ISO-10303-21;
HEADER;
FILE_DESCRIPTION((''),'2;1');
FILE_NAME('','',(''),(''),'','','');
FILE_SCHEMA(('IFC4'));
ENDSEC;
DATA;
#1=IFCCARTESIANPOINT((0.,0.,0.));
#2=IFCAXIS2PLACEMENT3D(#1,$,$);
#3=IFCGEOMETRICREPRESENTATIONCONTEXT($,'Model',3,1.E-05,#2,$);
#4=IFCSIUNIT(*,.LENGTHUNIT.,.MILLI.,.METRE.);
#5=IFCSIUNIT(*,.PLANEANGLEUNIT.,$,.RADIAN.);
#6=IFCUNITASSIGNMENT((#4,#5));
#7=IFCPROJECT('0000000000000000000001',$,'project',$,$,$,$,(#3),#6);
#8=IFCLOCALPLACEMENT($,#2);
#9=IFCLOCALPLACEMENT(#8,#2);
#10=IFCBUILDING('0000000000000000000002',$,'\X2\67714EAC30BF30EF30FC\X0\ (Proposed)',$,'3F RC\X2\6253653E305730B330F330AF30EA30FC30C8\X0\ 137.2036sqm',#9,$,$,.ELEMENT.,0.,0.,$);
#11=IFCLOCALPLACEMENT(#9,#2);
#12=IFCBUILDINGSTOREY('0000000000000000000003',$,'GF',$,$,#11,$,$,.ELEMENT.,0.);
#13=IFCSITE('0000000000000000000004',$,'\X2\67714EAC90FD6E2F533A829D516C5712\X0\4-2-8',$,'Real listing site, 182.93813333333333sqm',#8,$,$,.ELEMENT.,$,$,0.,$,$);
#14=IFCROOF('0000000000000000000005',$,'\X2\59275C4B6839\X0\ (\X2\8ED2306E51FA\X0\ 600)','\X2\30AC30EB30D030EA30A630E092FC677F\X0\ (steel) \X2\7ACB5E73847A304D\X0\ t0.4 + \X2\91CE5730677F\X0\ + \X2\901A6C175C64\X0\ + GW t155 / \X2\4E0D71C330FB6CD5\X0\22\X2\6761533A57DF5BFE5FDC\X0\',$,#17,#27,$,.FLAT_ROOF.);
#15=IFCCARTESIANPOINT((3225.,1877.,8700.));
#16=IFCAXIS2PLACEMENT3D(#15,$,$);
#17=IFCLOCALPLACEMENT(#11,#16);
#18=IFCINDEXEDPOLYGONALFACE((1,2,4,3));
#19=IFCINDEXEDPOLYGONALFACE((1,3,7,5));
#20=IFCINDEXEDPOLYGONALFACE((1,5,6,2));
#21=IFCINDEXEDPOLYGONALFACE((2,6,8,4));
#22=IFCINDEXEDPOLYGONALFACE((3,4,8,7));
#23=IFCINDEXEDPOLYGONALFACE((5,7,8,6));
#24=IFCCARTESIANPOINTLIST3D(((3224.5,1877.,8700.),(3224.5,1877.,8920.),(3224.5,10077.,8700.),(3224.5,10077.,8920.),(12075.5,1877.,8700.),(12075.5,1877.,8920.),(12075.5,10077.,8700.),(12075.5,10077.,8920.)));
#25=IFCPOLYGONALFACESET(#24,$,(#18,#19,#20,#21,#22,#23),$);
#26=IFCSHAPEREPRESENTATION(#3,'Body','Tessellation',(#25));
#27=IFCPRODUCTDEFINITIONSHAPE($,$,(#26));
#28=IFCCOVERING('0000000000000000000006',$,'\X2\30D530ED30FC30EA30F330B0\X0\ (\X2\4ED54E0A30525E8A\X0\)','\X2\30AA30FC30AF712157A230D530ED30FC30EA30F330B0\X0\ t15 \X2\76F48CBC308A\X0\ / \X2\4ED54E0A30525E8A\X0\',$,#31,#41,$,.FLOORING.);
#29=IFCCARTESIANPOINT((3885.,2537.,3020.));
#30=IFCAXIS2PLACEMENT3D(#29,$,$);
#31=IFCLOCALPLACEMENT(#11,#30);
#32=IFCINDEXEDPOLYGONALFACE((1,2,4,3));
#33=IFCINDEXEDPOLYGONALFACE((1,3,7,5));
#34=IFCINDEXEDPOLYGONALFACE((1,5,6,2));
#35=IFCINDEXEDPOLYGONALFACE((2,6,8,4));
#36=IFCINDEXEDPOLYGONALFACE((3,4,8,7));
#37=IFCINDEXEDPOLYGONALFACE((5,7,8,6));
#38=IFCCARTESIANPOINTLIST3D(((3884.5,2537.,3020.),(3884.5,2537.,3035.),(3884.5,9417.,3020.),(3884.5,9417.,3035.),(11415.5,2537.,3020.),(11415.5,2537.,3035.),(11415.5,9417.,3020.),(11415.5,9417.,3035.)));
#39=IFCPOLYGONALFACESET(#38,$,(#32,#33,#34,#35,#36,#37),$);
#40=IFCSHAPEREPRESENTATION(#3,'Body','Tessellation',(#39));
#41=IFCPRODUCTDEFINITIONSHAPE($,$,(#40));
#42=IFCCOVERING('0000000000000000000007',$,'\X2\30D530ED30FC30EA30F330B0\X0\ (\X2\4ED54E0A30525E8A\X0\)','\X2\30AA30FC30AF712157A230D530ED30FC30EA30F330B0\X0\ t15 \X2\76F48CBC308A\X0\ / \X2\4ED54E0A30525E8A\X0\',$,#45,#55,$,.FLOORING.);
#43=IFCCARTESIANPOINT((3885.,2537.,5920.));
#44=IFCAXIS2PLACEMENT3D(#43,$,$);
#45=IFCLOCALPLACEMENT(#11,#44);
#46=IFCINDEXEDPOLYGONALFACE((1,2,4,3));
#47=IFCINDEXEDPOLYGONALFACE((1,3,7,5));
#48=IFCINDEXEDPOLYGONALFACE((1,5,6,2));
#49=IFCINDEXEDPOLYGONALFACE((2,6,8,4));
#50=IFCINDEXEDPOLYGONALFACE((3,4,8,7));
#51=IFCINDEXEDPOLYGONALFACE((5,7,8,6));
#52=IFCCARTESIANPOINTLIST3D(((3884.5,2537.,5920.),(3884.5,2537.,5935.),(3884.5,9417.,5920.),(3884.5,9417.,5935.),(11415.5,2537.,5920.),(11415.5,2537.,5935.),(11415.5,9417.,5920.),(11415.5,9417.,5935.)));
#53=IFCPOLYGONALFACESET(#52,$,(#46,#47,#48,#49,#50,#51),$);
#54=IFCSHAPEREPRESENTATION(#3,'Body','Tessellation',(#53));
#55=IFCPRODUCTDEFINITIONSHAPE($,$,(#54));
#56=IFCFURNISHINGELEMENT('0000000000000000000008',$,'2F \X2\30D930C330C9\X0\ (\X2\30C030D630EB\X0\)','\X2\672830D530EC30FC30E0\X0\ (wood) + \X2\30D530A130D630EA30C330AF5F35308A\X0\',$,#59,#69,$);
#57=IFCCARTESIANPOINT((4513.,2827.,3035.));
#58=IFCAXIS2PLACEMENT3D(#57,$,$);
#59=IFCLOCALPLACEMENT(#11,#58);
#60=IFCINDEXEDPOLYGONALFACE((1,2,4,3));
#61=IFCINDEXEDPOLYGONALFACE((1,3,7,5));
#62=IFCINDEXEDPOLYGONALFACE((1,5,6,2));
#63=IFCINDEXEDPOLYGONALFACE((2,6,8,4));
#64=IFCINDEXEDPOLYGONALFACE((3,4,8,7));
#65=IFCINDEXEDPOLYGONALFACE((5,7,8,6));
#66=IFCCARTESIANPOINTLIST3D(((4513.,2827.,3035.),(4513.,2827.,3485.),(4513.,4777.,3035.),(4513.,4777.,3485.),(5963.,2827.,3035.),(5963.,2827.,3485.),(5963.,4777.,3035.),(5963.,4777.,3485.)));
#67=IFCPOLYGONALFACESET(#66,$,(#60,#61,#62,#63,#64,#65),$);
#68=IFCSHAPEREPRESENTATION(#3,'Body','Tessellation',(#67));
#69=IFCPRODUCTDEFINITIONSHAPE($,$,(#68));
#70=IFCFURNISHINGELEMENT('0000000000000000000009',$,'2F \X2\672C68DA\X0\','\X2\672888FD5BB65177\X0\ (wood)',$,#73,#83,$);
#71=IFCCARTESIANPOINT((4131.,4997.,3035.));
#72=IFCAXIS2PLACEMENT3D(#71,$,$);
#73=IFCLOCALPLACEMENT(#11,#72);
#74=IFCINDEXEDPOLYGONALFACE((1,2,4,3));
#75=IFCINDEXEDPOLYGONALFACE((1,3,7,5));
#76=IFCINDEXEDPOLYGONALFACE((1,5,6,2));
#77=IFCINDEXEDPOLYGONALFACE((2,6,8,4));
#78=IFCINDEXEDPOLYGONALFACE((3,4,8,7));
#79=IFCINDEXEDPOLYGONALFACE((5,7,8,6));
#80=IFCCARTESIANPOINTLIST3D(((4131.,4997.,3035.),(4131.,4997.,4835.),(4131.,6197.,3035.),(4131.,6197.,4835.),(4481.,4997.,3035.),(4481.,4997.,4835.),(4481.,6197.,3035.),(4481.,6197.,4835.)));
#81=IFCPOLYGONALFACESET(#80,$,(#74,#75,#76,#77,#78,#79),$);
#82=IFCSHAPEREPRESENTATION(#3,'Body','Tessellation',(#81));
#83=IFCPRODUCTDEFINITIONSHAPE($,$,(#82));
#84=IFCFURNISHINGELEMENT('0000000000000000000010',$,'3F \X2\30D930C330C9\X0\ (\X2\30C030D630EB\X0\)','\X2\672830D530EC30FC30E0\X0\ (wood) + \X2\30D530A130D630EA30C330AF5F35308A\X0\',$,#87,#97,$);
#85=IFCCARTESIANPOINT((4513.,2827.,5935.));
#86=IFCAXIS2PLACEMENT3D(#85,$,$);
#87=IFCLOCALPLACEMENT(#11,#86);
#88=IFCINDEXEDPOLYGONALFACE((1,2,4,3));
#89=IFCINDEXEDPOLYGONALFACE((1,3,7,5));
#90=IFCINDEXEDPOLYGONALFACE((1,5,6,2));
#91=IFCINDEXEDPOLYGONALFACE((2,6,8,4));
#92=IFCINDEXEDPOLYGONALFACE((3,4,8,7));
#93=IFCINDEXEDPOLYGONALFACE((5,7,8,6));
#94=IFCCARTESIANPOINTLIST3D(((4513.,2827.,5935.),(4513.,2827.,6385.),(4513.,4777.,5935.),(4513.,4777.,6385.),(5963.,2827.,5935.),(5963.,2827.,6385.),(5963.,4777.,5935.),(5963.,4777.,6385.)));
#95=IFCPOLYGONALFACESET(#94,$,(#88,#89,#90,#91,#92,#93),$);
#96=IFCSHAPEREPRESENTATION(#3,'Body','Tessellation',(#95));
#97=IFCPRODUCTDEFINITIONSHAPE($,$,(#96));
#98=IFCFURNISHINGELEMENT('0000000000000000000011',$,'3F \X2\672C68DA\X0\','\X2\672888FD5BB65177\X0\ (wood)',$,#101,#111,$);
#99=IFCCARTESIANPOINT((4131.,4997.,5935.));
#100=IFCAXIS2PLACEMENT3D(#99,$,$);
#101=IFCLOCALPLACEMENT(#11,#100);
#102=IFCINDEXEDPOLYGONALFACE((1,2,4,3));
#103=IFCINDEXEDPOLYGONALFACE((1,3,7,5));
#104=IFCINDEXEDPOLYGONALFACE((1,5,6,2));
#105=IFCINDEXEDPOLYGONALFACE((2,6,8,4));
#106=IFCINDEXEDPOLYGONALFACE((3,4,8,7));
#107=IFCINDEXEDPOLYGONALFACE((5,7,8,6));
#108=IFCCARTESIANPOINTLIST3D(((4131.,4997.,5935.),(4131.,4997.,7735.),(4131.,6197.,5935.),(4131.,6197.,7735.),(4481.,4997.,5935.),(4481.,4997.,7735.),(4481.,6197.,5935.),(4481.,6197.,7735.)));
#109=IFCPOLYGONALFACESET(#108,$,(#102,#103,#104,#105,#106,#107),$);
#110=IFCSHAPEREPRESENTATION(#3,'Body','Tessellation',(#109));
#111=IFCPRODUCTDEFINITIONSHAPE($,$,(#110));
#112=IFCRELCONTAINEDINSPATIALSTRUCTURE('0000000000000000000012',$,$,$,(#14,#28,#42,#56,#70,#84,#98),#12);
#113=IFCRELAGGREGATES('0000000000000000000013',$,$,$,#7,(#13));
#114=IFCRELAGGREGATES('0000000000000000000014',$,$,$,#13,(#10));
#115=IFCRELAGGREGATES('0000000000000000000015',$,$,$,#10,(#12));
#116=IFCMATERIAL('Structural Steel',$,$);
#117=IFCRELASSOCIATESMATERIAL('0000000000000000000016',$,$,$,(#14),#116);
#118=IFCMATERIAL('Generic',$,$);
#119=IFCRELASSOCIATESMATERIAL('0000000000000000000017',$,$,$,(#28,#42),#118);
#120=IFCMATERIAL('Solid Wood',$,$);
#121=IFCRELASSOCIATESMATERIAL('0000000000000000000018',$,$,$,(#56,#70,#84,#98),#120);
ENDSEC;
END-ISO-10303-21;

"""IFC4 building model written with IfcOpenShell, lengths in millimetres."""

from ifc_helpers import new_model, si_unit, frame, frame_2d, origin, place, context, project, spatial, rectangle, extrude, material, element, save


model = new_model("IFC4")

# Units and contexts
model_context = context("Model", 3, precision=1e-05, world=origin())
ifc_project = project(units=[si_unit("LENGTHUNIT", "METRE", prefix="MILLI"), si_unit("PLANEANGLEUNIT", "RADIAN")], contexts=[model_context])

# Site, building, storey
site_placement = place(None, origin())
site = spatial("IfcSite", under=ifc_project, at=site_placement, Name="東京都港区芝公園4-2-8", ObjectType="Real listing site, 182.93813333333333sqm", CompositionType="ELEMENT", RefElevation=0.0)
building_placement = place(site_placement, origin())
building = spatial("IfcBuilding", under=site, at=building_placement, Name="東京タワー (Proposed)", ObjectType="3F RC打放しコンクリート 137.2036sqm", CompositionType="ELEMENT", ElevationOfRefHeight=0.0, ElevationOfTerrain=0.0)
storey_placement = place(building_placement, origin())
storey = spatial("IfcBuildingStorey", under=building, at=storey_placement, Name="GF", CompositionType="ELEMENT", Elevation=0.0)

# Shared definitions
ifc_material_1 = material(Name="Solid Wood")

# Roof
ifc_material_2 = material(Name="Structural Steel")
roof_placement = place(storey_placement, frame((3225.0, 1877.0, 8700.0)))
element("IfcRoof", 1, at=roof_placement, inside=storey, material=ifc_material_2, Name="大屋根 (軒の出 600)", Description="ガルバリウム鋼板 (steel) 立平葺き t0.4 + 野地板 + 通気層 + GW t155 / 不燃・法22条区域対応", PredefinedType="FLAT_ROOF", context=model_context, shape_type="SweptSolid", body=[
    extrude(rectangle(XDim=8851.0, YDim=8200.0, at=frame_2d((4425.0, 4100.0))), frame((3225.0, 1877.0, 8700.0)), (0.0, 0.0, 1.0), 220.0),
])

# Coverings
ifc_material_3 = material(Name="Generic")
covering_1_placement = place(storey_placement, frame((3885.0, 2537.0, 3020.0)))
element("IfcCovering", 2, at=covering_1_placement, inside=storey, material=ifc_material_3, Name="フローリング (仕上げ床)", Description="オーク無垢フローリング t15 直貼り / 仕上げ床", PredefinedType="FLOORING", context=model_context, shape_type="SweptSolid", body=[
    extrude(rectangle(XDim=7531.0, YDim=6880.0, at=frame_2d((3765.0, 3440.0))), frame((3885.0, 2537.0, 3020.0)), (0.0, 0.0, 1.0), 15.0),
])
covering_2_placement = place(storey_placement, frame((3885.0, 2537.0, 5920.0)))
element("IfcCovering", 3, at=covering_2_placement, inside=storey, material=ifc_material_3, Name="フローリング (仕上げ床)", Description="オーク無垢フローリング t15 直貼り / 仕上げ床", PredefinedType="FLOORING", context=model_context, shape_type="SweptSolid", body=[
    extrude(rectangle(XDim=7531.0, YDim=6880.0, at=frame_2d((3765.0, 3440.0))), frame((3885.0, 2537.0, 5920.0)), (0.0, 0.0, 1.0), 15.0),
])

# Furnishing elements
furnishing_1_placement = place(storey_placement, frame((4513.0, 2827.0, 3035.0)))
element("IfcFurnishingElement", 4, at=furnishing_1_placement, inside=storey, material=ifc_material_1, Name="2F ベッド (ダブル)", Description="木フレーム (wood) + ファブリック張り", context=model_context, shape_type="SweptSolid", body=[
    extrude(rectangle(XDim=1450.0, YDim=1950.0, at=frame_2d((725.0, 975.0))), frame((4513.0, 2827.0, 3035.0)), (0.0, 0.0, 1.0), 450.0),
])
furnishing_2_placement = place(storey_placement, frame((4131.0, 4997.0, 3035.0)))
element("IfcFurnishingElement", 5, at=furnishing_2_placement, inside=storey, material=ifc_material_1, Name="2F 本棚", Description="木製家具 (wood)", context=model_context, shape_type="SweptSolid", body=[
    extrude(rectangle(XDim=350.0, YDim=1200.0, at=frame_2d((175.0, 600.0))), frame((4131.0, 4997.0, 3035.0)), (0.0, 0.0, 1.0), 1800.0),
])
furnishing_3_placement = place(storey_placement, frame((4513.0, 2827.0, 5935.0)))
element("IfcFurnishingElement", 6, at=furnishing_3_placement, inside=storey, material=ifc_material_1, Name="3F ベッド (ダブル)", Description="木フレーム (wood) + ファブリック張り", context=model_context, shape_type="SweptSolid", body=[
    extrude(rectangle(XDim=1450.0, YDim=1950.0, at=frame_2d((725.0, 975.0))), frame((4513.0, 2827.0, 5935.0)), (0.0, 0.0, 1.0), 450.0),
])
furnishing_4_placement = place(storey_placement, frame((4131.0, 4997.0, 5935.0)))
element("IfcFurnishingElement", 7, at=furnishing_4_placement, inside=storey, material=ifc_material_1, Name="3F 本棚", Description="木製家具 (wood)", context=model_context, shape_type="SweptSolid", body=[
    extrude(rectangle(XDim=350.0, YDim=1200.0, at=frame_2d((175.0, 600.0))), frame((4131.0, 4997.0, 5935.0)), (0.0, 0.0, 1.0), 1800.0),
])

save(model, "model.ifc")
